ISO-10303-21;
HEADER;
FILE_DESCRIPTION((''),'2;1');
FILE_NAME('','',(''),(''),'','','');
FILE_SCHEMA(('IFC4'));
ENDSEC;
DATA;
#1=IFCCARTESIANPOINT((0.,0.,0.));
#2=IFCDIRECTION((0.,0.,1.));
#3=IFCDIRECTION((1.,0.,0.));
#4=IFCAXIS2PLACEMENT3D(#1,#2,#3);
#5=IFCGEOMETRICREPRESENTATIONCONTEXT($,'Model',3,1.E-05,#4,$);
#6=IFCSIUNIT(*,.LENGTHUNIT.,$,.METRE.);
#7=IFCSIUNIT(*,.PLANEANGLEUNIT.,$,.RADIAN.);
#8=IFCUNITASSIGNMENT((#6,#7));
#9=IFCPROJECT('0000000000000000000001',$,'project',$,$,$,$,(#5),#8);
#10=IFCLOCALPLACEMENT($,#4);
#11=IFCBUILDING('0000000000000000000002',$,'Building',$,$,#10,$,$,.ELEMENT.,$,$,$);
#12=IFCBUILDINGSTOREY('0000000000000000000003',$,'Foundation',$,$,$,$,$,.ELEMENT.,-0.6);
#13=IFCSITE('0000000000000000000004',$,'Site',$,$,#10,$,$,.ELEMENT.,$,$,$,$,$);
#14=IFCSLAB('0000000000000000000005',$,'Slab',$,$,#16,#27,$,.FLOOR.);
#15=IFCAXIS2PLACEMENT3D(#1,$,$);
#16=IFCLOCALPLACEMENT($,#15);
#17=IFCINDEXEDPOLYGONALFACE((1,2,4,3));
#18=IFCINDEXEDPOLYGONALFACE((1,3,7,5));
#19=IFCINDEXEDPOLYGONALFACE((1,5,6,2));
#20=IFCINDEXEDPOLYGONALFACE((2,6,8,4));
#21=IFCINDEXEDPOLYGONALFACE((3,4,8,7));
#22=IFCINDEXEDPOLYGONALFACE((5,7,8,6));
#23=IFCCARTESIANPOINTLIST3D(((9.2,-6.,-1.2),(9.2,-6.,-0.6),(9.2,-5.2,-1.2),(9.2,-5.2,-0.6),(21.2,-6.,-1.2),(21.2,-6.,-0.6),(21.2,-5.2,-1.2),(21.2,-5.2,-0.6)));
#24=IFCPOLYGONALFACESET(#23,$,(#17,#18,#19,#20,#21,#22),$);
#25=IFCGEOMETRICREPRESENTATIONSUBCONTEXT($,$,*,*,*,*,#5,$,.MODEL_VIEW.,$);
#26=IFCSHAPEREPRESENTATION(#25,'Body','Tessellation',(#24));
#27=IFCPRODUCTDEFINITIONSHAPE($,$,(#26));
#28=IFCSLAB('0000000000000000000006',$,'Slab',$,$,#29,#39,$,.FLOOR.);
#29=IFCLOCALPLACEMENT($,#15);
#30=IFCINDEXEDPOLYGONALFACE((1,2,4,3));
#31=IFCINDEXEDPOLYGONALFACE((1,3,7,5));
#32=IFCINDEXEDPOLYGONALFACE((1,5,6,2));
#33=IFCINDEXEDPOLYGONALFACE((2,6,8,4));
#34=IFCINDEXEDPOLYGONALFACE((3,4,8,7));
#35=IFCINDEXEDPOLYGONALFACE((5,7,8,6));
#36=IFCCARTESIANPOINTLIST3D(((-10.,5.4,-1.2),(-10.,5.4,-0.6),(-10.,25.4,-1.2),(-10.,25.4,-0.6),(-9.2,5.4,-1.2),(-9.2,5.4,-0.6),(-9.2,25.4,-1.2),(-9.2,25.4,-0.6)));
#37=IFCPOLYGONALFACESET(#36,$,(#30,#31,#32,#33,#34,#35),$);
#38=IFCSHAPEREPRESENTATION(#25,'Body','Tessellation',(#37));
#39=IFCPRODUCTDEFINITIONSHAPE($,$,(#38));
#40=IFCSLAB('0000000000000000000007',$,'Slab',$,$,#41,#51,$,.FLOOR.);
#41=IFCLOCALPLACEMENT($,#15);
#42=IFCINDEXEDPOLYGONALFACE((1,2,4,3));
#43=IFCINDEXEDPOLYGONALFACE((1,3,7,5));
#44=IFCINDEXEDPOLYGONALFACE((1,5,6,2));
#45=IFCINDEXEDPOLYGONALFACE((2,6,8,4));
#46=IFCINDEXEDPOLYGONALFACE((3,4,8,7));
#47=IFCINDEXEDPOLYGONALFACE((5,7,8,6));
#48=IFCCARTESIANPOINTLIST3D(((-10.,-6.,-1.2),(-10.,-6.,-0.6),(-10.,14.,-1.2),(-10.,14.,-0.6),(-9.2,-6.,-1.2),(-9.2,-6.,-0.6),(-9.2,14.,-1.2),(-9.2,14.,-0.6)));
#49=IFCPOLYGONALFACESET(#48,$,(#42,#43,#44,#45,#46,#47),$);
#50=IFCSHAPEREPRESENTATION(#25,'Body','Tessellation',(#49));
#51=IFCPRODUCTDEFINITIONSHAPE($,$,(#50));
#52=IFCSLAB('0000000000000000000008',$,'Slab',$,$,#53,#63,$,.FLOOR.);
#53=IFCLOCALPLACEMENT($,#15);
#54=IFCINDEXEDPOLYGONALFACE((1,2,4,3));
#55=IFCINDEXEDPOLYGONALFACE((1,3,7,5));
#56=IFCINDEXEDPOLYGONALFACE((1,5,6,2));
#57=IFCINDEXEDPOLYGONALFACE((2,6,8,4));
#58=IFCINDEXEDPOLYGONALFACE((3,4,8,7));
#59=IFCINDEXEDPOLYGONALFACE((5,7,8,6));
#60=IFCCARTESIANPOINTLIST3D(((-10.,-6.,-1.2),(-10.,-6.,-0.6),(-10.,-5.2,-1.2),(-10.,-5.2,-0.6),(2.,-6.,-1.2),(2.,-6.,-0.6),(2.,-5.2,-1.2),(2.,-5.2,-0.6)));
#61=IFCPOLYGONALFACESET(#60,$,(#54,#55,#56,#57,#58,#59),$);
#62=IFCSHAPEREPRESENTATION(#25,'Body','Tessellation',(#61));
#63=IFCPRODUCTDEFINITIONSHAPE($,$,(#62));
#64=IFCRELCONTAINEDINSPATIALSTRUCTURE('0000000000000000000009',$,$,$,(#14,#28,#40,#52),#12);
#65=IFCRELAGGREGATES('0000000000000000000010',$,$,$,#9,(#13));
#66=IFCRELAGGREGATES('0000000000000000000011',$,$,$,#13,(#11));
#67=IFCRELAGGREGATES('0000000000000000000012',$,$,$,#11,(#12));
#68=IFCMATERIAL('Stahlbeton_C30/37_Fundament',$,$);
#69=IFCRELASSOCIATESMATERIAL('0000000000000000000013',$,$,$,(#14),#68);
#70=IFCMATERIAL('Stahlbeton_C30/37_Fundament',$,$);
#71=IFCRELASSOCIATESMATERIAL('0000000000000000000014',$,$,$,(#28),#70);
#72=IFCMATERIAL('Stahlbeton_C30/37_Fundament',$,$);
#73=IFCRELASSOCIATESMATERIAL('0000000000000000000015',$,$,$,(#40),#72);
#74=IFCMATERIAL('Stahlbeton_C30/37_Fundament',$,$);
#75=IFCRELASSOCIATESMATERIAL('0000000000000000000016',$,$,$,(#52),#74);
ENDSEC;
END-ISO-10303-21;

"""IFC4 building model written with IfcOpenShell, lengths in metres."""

from ifc_helpers import new_model, si_unit, frame, frame_2d, origin, origin_with_axes, place, context, subcontext, project, spatial, rectangle, extrude, material, element, save


model = new_model("IFC4")

# Units and contexts
model_context = context("Model", 3, precision=1e-05, world=origin_with_axes())
sub_context = subcontext(model_context, None, None, "MODEL_VIEW")
ifc_project = project(units=[si_unit("LENGTHUNIT", "METRE"), si_unit("PLANEANGLEUNIT", "RADIAN")], contexts=[model_context])

# Site, building, storey
placement_1 = place(None, origin_with_axes())
site = spatial("IfcSite", under=ifc_project, at=placement_1, Name="Site", CompositionType="ELEMENT")
building = spatial("IfcBuilding", under=site, at=placement_1, Name="Building", CompositionType="ELEMENT")
storey = spatial("IfcBuildingStorey", under=building, Name="Foundation", CompositionType="ELEMENT", Elevation=-0.6)

# Slabs
ifc_material_1 = material(Name="Stahlbeton_C30/37_Fundament")
placement_2 = place(None, origin_with_axes())
placement_3 = place(placement_2, frame((0.0, 0.0, -0.6)))
slab_1_placement = place(placement_3, frame((9.2, -6.0, -0.6)))
element("IfcSlab", 1, at=slab_1_placement, inside=storey, material=ifc_material_1, Name="Slab", PredefinedType="FLOOR", context=sub_context, shape_type="SweptSolid", body=[
    extrude(rectangle(XDim=12.0, YDim=0.8, at=frame_2d((6.0, 0.4))), origin(), (0.0, 0.0, 1.0), 0.6),
])
ifc_material_2 = material(Name="Stahlbeton_C30/37_Fundament")
placement_4 = place(None, origin_with_axes())
placement_5 = place(placement_4, frame((0.0, 0.0, -0.6)))
slab_2_placement = place(placement_5, frame((-10.0, 5.4, -0.6)))
element("IfcSlab", 2, at=slab_2_placement, inside=storey, material=ifc_material_2, Name="Slab", PredefinedType="FLOOR", context=sub_context, shape_type="SweptSolid", body=[
    extrude(rectangle(XDim=0.8, YDim=20.0, at=frame_2d((0.4, 10.0))), origin(), (0.0, 0.0, 1.0), 0.6),
])
ifc_material_3 = material(Name="Stahlbeton_C30/37_Fundament")
placement_6 = place(None, origin_with_axes())
placement_7 = place(placement_6, frame((0.0, 0.0, -0.6)))
slab_3_placement = place(placement_7, frame((-10.0, -6.0, -0.6)))
element("IfcSlab", 3, at=slab_3_placement, inside=storey, material=ifc_material_3, Name="Slab", PredefinedType="FLOOR", context=sub_context, shape_type="SweptSolid", body=[
    extrude(rectangle(XDim=0.8, YDim=20.0, at=frame_2d((0.4, 10.0))), origin(), (0.0, 0.0, 1.0), 0.6),
])
ifc_material_4 = material(Name="Stahlbeton_C30/37_Fundament")
placement_8 = place(None, origin_with_axes())
placement_9 = place(placement_8, frame((0.0, 0.0, -0.6)))
slab_4_placement = place(placement_9, frame((-10.0, -6.0, -0.6)))
element("IfcSlab", 4, at=slab_4_placement, inside=storey, material=ifc_material_4, Name="Slab", PredefinedType="FLOOR", context=sub_context, shape_type="SweptSolid", body=[
    extrude(rectangle(XDim=12.0, YDim=0.8, at=frame_2d((6.0, 0.4))), origin(), (0.0, 0.0, 1.0), 0.6),
])

save(model, "model.ifc")
